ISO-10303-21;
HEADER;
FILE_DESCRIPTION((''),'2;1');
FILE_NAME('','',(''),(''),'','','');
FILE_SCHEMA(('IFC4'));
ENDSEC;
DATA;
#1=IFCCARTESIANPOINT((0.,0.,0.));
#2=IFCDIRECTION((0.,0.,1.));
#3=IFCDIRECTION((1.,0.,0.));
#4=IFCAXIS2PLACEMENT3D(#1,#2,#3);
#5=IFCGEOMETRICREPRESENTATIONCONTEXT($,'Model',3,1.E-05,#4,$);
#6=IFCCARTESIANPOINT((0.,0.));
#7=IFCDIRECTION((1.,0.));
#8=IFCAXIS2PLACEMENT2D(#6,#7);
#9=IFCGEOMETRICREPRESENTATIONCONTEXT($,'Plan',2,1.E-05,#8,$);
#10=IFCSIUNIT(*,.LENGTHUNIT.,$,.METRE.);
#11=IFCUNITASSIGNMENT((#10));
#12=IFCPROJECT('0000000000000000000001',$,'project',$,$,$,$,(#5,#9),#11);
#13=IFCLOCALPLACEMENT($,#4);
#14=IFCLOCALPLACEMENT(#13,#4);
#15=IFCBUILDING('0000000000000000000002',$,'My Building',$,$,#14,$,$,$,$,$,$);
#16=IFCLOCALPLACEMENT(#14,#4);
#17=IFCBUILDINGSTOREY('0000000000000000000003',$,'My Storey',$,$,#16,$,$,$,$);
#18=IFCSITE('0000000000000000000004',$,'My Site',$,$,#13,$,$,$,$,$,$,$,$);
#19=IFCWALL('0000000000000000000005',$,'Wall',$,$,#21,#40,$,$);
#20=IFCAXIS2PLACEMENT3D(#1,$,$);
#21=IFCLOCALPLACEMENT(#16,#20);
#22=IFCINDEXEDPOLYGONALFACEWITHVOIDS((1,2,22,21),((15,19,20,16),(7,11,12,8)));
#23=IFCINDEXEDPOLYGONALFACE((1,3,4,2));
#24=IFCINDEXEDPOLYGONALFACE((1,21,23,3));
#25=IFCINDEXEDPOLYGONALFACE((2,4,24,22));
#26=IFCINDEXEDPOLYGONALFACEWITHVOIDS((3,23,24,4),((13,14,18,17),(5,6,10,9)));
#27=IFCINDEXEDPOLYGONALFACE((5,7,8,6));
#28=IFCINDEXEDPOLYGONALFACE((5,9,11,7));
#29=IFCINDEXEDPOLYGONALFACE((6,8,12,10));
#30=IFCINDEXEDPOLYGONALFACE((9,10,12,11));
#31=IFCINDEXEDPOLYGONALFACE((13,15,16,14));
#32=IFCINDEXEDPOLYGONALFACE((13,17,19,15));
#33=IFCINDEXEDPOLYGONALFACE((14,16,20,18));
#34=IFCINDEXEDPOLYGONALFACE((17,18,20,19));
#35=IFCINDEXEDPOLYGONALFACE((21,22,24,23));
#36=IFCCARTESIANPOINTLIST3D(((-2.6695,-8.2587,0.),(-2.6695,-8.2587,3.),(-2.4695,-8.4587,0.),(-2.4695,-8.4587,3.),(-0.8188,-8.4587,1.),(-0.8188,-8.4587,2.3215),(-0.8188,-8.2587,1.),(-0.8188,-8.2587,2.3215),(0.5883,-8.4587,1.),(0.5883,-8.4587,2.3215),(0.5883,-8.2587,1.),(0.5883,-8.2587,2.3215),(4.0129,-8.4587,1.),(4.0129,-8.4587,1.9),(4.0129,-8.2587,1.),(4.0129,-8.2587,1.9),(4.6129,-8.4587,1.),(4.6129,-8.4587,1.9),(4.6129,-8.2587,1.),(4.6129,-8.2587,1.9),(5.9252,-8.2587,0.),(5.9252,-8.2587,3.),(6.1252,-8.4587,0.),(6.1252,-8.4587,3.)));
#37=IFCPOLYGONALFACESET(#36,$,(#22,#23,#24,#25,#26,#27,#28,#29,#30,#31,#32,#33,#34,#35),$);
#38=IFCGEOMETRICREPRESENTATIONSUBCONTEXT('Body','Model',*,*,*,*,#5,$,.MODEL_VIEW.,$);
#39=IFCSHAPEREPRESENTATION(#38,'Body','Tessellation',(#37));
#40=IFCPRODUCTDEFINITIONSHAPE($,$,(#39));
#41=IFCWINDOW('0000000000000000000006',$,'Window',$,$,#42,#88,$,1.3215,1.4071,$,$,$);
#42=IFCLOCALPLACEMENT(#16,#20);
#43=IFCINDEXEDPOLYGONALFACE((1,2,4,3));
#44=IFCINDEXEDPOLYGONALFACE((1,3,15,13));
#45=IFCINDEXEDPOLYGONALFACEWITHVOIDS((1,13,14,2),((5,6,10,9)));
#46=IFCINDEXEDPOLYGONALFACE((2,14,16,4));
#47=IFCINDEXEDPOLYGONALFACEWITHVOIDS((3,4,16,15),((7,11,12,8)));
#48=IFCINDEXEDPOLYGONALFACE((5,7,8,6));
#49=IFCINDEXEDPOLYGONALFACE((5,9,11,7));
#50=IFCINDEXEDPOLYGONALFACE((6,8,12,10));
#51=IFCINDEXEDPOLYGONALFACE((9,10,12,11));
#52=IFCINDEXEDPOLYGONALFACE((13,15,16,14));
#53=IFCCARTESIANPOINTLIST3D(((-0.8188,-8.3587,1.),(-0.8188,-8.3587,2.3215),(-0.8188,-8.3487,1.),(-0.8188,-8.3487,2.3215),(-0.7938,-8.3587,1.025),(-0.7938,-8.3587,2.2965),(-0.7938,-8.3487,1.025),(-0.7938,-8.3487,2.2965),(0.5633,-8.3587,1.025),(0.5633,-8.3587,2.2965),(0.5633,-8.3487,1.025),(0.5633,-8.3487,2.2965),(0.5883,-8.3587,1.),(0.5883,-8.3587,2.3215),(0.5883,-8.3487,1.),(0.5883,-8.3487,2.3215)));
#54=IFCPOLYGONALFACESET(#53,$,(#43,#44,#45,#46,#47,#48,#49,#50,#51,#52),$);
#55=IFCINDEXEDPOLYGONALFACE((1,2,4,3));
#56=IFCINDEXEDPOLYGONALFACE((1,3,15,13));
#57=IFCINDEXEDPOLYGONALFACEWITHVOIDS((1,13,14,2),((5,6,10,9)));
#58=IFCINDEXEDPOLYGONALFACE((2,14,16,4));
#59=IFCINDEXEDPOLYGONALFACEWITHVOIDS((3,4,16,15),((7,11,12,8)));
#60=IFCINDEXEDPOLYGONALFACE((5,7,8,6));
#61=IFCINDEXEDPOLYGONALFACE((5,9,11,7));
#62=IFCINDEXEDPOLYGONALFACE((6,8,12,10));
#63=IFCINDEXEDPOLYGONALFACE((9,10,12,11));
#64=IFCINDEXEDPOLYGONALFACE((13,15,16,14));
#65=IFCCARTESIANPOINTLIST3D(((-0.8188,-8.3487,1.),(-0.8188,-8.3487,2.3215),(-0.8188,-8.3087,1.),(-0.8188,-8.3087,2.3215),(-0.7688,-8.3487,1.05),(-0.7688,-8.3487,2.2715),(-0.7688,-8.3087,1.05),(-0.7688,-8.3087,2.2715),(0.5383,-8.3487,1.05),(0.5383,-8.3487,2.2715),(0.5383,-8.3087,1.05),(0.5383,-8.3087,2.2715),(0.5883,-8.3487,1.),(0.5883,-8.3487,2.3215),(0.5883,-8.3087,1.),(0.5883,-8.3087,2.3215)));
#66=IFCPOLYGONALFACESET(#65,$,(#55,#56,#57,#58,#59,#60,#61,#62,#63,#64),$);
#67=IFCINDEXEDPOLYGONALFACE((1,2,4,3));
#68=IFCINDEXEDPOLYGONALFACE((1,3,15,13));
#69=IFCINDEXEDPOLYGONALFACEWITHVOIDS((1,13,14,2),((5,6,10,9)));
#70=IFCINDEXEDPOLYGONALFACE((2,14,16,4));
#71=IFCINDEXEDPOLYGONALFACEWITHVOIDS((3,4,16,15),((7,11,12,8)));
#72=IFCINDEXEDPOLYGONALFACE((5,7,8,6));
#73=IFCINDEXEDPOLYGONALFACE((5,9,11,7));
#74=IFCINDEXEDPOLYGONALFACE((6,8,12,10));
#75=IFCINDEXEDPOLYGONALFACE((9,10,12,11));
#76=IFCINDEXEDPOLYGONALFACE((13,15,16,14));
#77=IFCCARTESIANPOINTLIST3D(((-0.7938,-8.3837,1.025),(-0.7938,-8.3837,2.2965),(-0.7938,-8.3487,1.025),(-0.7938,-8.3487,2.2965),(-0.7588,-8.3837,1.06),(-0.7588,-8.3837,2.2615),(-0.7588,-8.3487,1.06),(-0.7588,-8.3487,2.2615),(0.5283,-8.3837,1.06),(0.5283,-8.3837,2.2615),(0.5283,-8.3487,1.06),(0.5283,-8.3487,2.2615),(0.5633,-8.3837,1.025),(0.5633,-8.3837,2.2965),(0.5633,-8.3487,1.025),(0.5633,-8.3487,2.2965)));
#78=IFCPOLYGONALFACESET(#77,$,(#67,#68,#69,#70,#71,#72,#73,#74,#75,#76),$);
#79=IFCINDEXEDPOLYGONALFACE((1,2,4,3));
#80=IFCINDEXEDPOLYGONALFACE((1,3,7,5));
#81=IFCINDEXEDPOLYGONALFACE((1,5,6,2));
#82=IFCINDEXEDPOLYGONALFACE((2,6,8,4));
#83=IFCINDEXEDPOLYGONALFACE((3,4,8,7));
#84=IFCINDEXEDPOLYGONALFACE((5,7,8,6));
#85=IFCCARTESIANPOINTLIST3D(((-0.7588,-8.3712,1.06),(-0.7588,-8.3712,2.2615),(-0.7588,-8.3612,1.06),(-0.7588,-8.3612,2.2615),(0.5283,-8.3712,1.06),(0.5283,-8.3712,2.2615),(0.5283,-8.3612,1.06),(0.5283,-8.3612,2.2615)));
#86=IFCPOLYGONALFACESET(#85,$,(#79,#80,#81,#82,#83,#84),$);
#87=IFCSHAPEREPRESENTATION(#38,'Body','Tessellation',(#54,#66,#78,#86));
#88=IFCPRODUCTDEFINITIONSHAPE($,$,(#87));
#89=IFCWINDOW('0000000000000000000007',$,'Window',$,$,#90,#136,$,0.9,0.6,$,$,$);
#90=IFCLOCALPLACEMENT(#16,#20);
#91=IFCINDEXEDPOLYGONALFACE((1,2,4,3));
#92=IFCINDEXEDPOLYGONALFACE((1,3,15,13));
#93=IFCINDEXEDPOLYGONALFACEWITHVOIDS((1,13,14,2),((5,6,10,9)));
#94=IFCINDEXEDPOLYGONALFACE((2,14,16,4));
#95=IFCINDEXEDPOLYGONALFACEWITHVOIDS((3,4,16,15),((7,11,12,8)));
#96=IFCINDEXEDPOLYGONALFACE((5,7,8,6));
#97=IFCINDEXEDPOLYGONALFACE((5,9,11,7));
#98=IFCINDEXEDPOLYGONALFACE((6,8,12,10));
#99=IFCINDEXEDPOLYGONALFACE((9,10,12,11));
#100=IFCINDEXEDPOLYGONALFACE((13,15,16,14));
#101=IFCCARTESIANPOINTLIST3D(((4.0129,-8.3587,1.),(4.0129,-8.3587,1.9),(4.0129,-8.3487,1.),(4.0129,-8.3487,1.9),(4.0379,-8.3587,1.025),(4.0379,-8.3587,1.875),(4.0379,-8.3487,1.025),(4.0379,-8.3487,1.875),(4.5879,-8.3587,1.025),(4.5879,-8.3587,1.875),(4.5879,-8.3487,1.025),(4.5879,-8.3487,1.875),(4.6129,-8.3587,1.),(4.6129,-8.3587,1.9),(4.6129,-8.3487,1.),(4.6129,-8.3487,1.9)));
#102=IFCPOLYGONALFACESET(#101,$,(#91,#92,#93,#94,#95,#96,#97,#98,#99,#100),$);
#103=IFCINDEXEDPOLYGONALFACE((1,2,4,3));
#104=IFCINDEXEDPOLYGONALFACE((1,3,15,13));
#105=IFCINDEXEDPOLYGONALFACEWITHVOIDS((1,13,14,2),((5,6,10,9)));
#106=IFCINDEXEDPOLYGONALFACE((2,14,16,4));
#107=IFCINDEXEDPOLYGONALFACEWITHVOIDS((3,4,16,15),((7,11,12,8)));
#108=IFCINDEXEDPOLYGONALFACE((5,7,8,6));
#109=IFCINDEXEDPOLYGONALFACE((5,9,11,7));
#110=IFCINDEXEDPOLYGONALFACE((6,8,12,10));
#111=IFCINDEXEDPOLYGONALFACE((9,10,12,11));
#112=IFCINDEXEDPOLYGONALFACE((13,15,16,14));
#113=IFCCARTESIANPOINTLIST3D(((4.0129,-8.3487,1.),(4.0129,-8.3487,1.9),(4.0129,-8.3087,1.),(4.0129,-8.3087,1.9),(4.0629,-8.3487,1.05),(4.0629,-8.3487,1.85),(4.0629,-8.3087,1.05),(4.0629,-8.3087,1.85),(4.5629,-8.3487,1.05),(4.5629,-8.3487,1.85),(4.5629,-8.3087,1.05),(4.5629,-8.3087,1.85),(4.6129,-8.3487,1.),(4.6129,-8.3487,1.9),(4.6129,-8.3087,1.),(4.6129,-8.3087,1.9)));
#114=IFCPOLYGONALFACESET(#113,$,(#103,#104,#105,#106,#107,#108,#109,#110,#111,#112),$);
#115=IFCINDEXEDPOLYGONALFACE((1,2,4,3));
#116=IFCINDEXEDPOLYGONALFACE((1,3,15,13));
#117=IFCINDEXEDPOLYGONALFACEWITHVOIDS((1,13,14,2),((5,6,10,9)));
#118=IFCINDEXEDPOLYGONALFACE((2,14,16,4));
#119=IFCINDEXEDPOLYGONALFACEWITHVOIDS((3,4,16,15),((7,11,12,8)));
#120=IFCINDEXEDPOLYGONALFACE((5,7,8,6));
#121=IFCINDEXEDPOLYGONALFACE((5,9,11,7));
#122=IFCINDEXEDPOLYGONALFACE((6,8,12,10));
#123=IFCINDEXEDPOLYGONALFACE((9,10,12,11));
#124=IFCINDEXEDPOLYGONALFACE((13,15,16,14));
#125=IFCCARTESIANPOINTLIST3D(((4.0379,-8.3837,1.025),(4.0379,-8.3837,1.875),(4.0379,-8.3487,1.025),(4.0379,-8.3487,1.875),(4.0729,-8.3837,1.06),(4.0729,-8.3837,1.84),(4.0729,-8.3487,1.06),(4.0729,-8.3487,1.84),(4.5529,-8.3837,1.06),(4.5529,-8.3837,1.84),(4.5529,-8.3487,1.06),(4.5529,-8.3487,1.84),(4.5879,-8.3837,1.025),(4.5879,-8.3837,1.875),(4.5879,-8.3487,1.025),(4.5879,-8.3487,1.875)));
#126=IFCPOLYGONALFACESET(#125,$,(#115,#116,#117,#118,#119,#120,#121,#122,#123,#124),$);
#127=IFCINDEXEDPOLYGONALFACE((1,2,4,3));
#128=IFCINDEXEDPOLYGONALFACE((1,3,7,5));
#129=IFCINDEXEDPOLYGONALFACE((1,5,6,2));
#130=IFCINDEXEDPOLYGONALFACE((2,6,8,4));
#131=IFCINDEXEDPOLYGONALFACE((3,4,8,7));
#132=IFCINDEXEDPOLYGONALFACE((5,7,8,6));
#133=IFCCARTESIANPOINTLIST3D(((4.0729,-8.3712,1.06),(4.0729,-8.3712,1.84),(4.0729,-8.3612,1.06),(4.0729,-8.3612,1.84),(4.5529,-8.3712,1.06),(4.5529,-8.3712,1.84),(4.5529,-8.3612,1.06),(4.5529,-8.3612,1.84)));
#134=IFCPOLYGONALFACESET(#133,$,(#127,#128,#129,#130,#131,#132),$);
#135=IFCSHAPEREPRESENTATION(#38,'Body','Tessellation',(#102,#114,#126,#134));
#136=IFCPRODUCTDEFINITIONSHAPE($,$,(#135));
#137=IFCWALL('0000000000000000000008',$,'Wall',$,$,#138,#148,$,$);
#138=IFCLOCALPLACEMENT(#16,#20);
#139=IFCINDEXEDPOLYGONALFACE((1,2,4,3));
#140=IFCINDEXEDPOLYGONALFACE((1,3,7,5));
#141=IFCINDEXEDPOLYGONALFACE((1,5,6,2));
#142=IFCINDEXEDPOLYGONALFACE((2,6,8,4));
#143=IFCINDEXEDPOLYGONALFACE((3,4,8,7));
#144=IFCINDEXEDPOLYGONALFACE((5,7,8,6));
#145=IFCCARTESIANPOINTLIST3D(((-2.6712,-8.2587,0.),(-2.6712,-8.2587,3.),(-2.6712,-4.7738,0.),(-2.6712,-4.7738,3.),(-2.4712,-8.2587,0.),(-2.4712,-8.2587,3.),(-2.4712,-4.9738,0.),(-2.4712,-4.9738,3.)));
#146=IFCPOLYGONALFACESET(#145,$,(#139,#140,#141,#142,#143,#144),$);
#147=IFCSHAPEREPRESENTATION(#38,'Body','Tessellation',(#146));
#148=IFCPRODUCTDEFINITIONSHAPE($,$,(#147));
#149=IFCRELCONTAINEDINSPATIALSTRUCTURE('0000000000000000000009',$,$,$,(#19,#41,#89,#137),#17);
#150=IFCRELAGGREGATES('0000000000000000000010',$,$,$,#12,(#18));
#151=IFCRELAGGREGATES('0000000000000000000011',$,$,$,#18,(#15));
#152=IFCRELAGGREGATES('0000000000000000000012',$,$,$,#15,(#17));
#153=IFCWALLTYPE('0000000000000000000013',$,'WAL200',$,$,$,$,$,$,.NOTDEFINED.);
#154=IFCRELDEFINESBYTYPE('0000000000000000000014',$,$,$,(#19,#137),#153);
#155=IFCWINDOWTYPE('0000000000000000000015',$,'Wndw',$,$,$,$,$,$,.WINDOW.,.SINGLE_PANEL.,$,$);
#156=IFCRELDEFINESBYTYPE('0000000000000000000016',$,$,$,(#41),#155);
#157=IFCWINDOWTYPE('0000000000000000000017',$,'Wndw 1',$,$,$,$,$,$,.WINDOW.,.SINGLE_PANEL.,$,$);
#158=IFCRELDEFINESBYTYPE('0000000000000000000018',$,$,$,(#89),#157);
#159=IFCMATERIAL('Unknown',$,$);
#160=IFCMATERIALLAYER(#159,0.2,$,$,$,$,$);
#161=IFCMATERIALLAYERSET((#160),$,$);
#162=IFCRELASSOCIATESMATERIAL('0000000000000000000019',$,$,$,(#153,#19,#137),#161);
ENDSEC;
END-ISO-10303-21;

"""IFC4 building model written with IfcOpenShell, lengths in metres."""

from ifc_helpers import new_model, entity, si_unit, frame, origin_with_axes, origin_2d_with_axis, place, context, subcontext, project, spatial, line, indexed_curve, outline, extrude, shape, source, transform, mapped, material, layer, layer_set, layer_usage, type_object, type_shapes, element, fill, save


model = new_model("IFC4")

# Units and contexts
model_context = context("Model", 3, precision=1e-05, world=origin_with_axes())
plan_context = context("Plan", 2, precision=1e-05, world=origin_2d_with_axis())
body_context_1 = subcontext(model_context, "Body", "Model", "MODEL_VIEW")
body_context_2 = subcontext(plan_context, "Body", "Plan", "PLAN_VIEW")
ifc_project = project(units=[si_unit("LENGTHUNIT", "METRE")], contexts=[model_context, plan_context])

# Site, building, storey
site_placement = place(None, origin_with_axes())
site = spatial("IfcSite", under=ifc_project, at=site_placement, Name="My Site")
building_placement = place(site_placement, origin_with_axes())
building = spatial("IfcBuilding", under=site, at=building_placement, Name="My Building")
storey_placement = place(building_placement, origin_with_axes())
storey = spatial("IfcBuildingStorey", under=building, at=storey_placement, Name="My Storey")

# Shared definitions
ifc_material = material(Name="Unknown")

# Shared definitions
ifc_layer_1 = layer(ifc_material, 0.2)
ifc_layer_set_1 = layer_set([ifc_layer_1])
wall_type_1 = type_object("IfcWallType", Name="WAL200", PredefinedType="NOTDEFINED", material=ifc_layer_set_1)

# Wall, openings, windows
ifc_layer_usage_1 = layer_usage(ifc_layer_set_1, "AXIS2", "POSITIVE", 0.0)
wall_1_placement = place(storey_placement, frame((-2.4695, -8.4587, 0.0), z_axis=(0.0, 0.0, 1.0), x_axis=(1.0, 0.0, 0.0)))
wall_1 = element("IfcWall", 1, at=wall_1_placement, inside=storey, type_object=wall_type_1, material=ifc_layer_usage_1, Name="Wall", context=body_context_1, shape_type="SweptSolid", body=[
    extrude(outline(indexed_curve([(0.0, 0.0), (-0.2, 0.2), (8.3947, 0.2), (8.5947, 0.0)], segments=[line(1, 2, 3, 4, 1)])), origin_with_axes(), (0.0, 0.0, 1.0), 3.0),
])
shared_shape_1 = source(origin_with_axes(), body_context_1, "Body", "SweptSolid", [
    extrude(outline(indexed_curve([(0.0, 0.0), (1.4071, 0.0), (1.4071, 1.3215), (0.0, 1.3215)], segments=[line(1, 2, 3, 4, 1)])), frame((0.0, -0.6, 0.0), z_axis=(0.0, -1.0, 0.0), x_axis=(1.0, 0.0, 0.0)), (0.0, 0.0, -1.0), 1.2),
])
opening_1_placement = place(wall_1_placement, frame((3.0579, 0.2, 1.0), z_axis=(0.0, 0.0, 1.0), x_axis=(-1.0, 0.0, 0.0)))
opening_1 = element("IfcOpeningElement", 2, at=opening_1_placement, cuts=wall_1, PredefinedType="OPENING", context=body_context_1, shape_type="MappedRepresentation", body=[
    mapped(shared_shape_1, transform((0.0, 0.0, 0.0), x_axis=(1.0, 0.0, 0.0), y_axis=(0.0, 1.0, 0.0), z_axis=(0.0, 0.0, 1.0), scale=1.0)),
])
shared_shape_2 = source(origin_with_axes(), body_context_1, "Body", "SweptSolid", [
    extrude(outline(indexed_curve([(0.0, 0.0), (0.6, 0.0), (0.6, 0.9), (0.0, 0.9)], segments=[line(1, 2, 3, 4, 1)])), frame((0.0, -0.6, 0.0), z_axis=(0.0, -1.0, 0.0), x_axis=(1.0, 0.0, 0.0)), (0.0, 0.0, -1.0), 1.2),
])
opening_2_placement = place(wall_1_placement, frame((7.0824, 0.2, 1.0), z_axis=(0.0, 0.0, 1.0), x_axis=(-1.0, 0.0, 0.0)))
opening_2 = element("IfcOpeningElement", 3, at=opening_2_placement, cuts=wall_1, PredefinedType="OPENING", context=body_context_1, shape_type="MappedRepresentation", body=[
    mapped(shared_shape_2, transform((0.0, 0.0, 0.0), x_axis=(1.0, 0.0, 0.0), y_axis=(0.0, 1.0, 0.0), z_axis=(0.0, 0.0, 1.0), scale=1.0)),
])
window_type_1 = type_object("IfcWindowType", Name="Wndw", PartitioningType="SINGLE_PANEL", PredefinedType="WINDOW")
shared_shape_3 = source(origin_with_axes(), body_context_1, "Body", "SweptSolid", [
    extrude(outline(indexed_curve([(0.0, 0.0), (1.4071, 0.0), (1.4071, 1.3215), (0.0, 1.3215)], segments=[line(1, 2, 3, 4, 1)]), holes=[indexed_curve([(0.025, 0.025), (1.3821, 0.025), (1.3821, 1.2965), (0.025, 1.2965)], segments=[line(1, 2, 3, 4, 1)])]), frame((0.0, 0.09, 0.0), z_axis=(0.0, -1.0, 0.0), x_axis=(1.0, 0.0, 0.0)), (0.0, 0.0, -1.0), 0.01),
    extrude(outline(indexed_curve([(0.0, 0.0), (1.4071, 0.0), (1.4071, 1.3215), (0.0, 1.3215)], segments=[line(1, 2, 3, 4, 1)]), holes=[indexed_curve([(0.05, 0.05), (1.3571, 0.05), (1.3571, 1.2715), (0.05, 1.2715)], segments=[line(1, 2, 3, 4, 1)])]), frame((0.0, 0.05, 0.0), z_axis=(0.0, -1.0, 0.0), x_axis=(1.0, 0.0, 0.0)), (0.0, 0.0, -1.0), 0.04),
    extrude(outline(indexed_curve([(0.0, 0.0), (1.3571, 0.0), (1.3571, 1.2715), (0.0, 1.2715)], segments=[line(1, 2, 3, 4, 1)]), holes=[indexed_curve([(0.035, 0.035), (1.3221, 0.035), (1.3221, 1.2365), (0.035, 1.2365)], segments=[line(1, 2, 3, 4, 1)])]), frame((0.025, 0.09, 0.025), z_axis=(0.0, -1.0, 0.0), x_axis=(1.0, 0.0, 0.0)), (0.0, 0.0, -1.0), 0.035),
    extrude(outline(indexed_curve([(0.035, 0.035), (1.3221, 0.035), (1.3221, 1.2365), (0.035, 1.2365)], segments=[line(1, 2, 3, 4, 1)])), frame((0.025, 0.1025, 0.025), z_axis=(0.0, -1.0, 0.0), x_axis=(1.0, 0.0, 0.0)), (0.0, 0.0, -1.0), 0.01),
])
shared_shape_4 = source(origin_with_axes(), body_context_2, "Body", "Curve2D", [
    entity("IfcIndexedPolyCurve", entity("IfcCartesianPointList2D", [[0.05, 0.05], [1.3571, 0.05]])),
    entity("IfcIndexedPolyCurve", entity("IfcCartesianPointList2D", [[0.0, 0.1], [0.025, 0.1], [0.025, 0.09], [0.05, 0.09], [0.05, 0.05], [0.0, 0.05]]), [entity("IfcLineIndex", [1, 2, 3, 4, 5, 6, 1])]),
    entity("IfcIndexedPolyCurve", entity("IfcCartesianPointList2D", [[1.4071, 0.1], [1.3821, 0.1], [1.3821, 0.09], [1.3571, 0.09], [1.3571, 0.05], [1.4071, 0.05]]), [entity("IfcLineIndex", [1, 2, 3, 4, 5, 6, 1])]),
    entity("IfcIndexedPolyCurve", entity("IfcCartesianPointList2D", [[0.025, 0.09], [0.06, 0.09], [0.06, 0.125], [0.025, 0.125]]), [entity("IfcLineIndex", [1, 2, 3, 4, 1])]),
    entity("IfcIndexedPolyCurve", entity("IfcCartesianPointList2D", [[1.3821, 0.09], [1.3471, 0.09], [1.3471, 0.125], [1.3821, 0.125]]), [entity("IfcLineIndex", [1, 2, 3, 4, 1])]),
    entity("IfcIndexedPolyCurve", entity("IfcCartesianPointList2D", [[0.06, 0.09], [1.3471, 0.09]])),
    entity("IfcIndexedPolyCurve", entity("IfcCartesianPointList2D", [[0.06, 0.125], [1.3471, 0.125]])),
    entity("IfcIndexedPolyCurve", entity("IfcCartesianPointList2D", [[0.06, 0.1075], [1.3471, 0.1075]])),
])
type_shapes(window_type_1, [shared_shape_3, shared_shape_4])
window_1_placement = place(opening_1_placement, origin_with_axes())
window_1 = element("IfcWindow", 4, at=window_1_placement, inside=storey, type_object=window_type_1, Name="Window", OverallHeight=1.3215, OverallWidth=1.4071, shapes=[
    shape(body_context_1, "Body", "MappedRepresentation", [mapped(shared_shape_3, transform((0.0, 0.0, 0.0), x_axis=(1.0, 0.0, 0.0), y_axis=(0.0, 1.0, 0.0), z_axis=(0.0, 0.0, 1.0), scale=1.0))]),
    shape(body_context_2, "Body", "MappedRepresentation", [mapped(shared_shape_4, transform((0.0, 0.0, 0.0), x_axis=(1.0, 0.0, 0.0), y_axis=(0.0, 1.0, 0.0), z_axis=(0.0, 0.0, 1.0), scale=1.0))]),
])
fill(opening_1, window_1)
window_type_2 = type_object("IfcWindowType", Name="Wndw 1", PartitioningType="SINGLE_PANEL", PredefinedType="WINDOW")
shared_shape_5 = source(origin_with_axes(), body_context_1, "Body", "SweptSolid", [
    extrude(outline(indexed_curve([(0.0, 0.0), (0.6, 0.0), (0.6, 0.9), (0.0, 0.9)], segments=[line(1, 2, 3, 4, 1)]), holes=[indexed_curve([(0.025, 0.025), (0.575, 0.025), (0.575, 0.875), (0.025, 0.875)], segments=[line(1, 2, 3, 4, 1)])]), frame((0.0, 0.09, 0.0), z_axis=(0.0, -1.0, 0.0), x_axis=(1.0, 0.0, 0.0)), (0.0, 0.0, -1.0), 0.01),
    extrude(outline(indexed_curve([(0.0, 0.0), (0.6, 0.0), (0.6, 0.9), (0.0, 0.9)], segments=[line(1, 2, 3, 4, 1)]), holes=[indexed_curve([(0.05, 0.05), (0.55, 0.05), (0.55, 0.85), (0.05, 0.85)], segments=[line(1, 2, 3, 4, 1)])]), frame((0.0, 0.05, 0.0), z_axis=(0.0, -1.0, 0.0), x_axis=(1.0, 0.0, 0.0)), (0.0, 0.0, -1.0), 0.04),
    extrude(outline(indexed_curve([(0.0, 0.0), (0.55, 0.0), (0.55, 0.85), (0.0, 0.85)], segments=[line(1, 2, 3, 4, 1)]), holes=[indexed_curve([(0.035, 0.035), (0.515, 0.035), (0.515, 0.815), (0.035, 0.815)], segments=[line(1, 2, 3, 4, 1)])]), frame((0.025, 0.09, 0.025), z_axis=(0.0, -1.0, 0.0), x_axis=(1.0, 0.0, 0.0)), (0.0, 0.0, -1.0), 0.035),
    extrude(outline(indexed_curve([(0.035, 0.035), (0.515, 0.035), (0.515, 0.815), (0.035, 0.815)], segments=[line(1, 2, 3, 4, 1)])), frame((0.025, 0.1025, 0.025), z_axis=(0.0, -1.0, 0.0), x_axis=(1.0, 0.0, 0.0)), (0.0, 0.0, -1.0), 0.01),
])
shared_shape_6 = source(origin_with_axes(), body_context_2, "Body", "Curve2D", [
    entity("IfcIndexedPolyCurve", entity("IfcCartesianPointList2D", [[0.05, 0.05], [0.55, 0.05]])),
    entity("IfcIndexedPolyCurve", entity("IfcCartesianPointList2D", [[0.0, 0.1], [0.025, 0.1], [0.025, 0.09], [0.05, 0.09], [0.05, 0.05], [0.0, 0.05]]), [entity("IfcLineIndex", [1, 2, 3, 4, 5, 6, 1])]),
    entity("IfcIndexedPolyCurve", entity("IfcCartesianPointList2D", [[0.6, 0.1], [0.575, 0.1], [0.575, 0.09], [0.55, 0.09], [0.55, 0.05], [0.6, 0.05]]), [entity("IfcLineIndex", [1, 2, 3, 4, 5, 6, 1])]),
    entity("IfcIndexedPolyCurve", entity("IfcCartesianPointList2D", [[0.025, 0.09], [0.06, 0.09], [0.06, 0.125], [0.025, 0.125]]), [entity("IfcLineIndex", [1, 2, 3, 4, 1])]),
    entity("IfcIndexedPolyCurve", entity("IfcCartesianPointList2D", [[0.575, 0.09], [0.54, 0.09], [0.54, 0.125], [0.575, 0.125]]), [entity("IfcLineIndex", [1, 2, 3, 4, 1])]),
    entity("IfcIndexedPolyCurve", entity("IfcCartesianPointList2D", [[0.06, 0.09], [0.54, 0.09]])),
    entity("IfcIndexedPolyCurve", entity("IfcCartesianPointList2D", [[0.06, 0.125], [0.54, 0.125]])),
    entity("IfcIndexedPolyCurve", entity("IfcCartesianPointList2D", [[0.06, 0.1075], [0.54, 0.1075]])),
])
type_shapes(window_type_2, [shared_shape_5, shared_shape_6])
window_2_placement = place(opening_2_placement, frame((0.0, 0.0, 0.0), z_axis=(0.0, 0.0, 1.0), x_axis=(1.0, 0.0, 0.0)))
window_2 = element("IfcWindow", 5, at=window_2_placement, inside=storey, type_object=window_type_2, Name="Window", OverallHeight=0.9, OverallWidth=0.6, shapes=[
    shape(body_context_1, "Body", "MappedRepresentation", [mapped(shared_shape_5, transform((0.0, 0.0, 0.0), x_axis=(1.0, 0.0, 0.0), y_axis=(0.0, 1.0, 0.0), z_axis=(0.0, 0.0, 1.0), scale=1.0))]),
    shape(body_context_2, "Body", "MappedRepresentation", [mapped(shared_shape_6, transform((0.0, 0.0, 0.0), x_axis=(1.0, 0.0, 0.0), y_axis=(0.0, 1.0, 0.0), z_axis=(0.0, 0.0, 1.0), scale=1.0))]),
])
fill(opening_2, window_2)

# Wall
ifc_layer_usage_2 = layer_usage(ifc_layer_set_1, "AXIS2", "POSITIVE", 0.0)
wall_2_placement = place(storey_placement, frame((-2.6712, -4.7738, 0.0), z_axis=(0.0, 0.0, 1.0), x_axis=(0.0, -1.0, 0.0)))
element("IfcWall", 6, at=wall_2_placement, inside=storey, type_object=wall_type_1, material=ifc_layer_usage_2, Name="Wall", context=body_context_1, shape_type="SweptSolid", body=[
    extrude(outline(indexed_curve([(0.0, 0.0), (0.2, 0.2), (3.485, 0.2), (3.485, 0.0)], segments=[line(1, 2, 3, 4, 1)])), origin_with_axes(), (0.0, 0.0, 1.0), 3.0),
])

save(model, "model.ifc")
